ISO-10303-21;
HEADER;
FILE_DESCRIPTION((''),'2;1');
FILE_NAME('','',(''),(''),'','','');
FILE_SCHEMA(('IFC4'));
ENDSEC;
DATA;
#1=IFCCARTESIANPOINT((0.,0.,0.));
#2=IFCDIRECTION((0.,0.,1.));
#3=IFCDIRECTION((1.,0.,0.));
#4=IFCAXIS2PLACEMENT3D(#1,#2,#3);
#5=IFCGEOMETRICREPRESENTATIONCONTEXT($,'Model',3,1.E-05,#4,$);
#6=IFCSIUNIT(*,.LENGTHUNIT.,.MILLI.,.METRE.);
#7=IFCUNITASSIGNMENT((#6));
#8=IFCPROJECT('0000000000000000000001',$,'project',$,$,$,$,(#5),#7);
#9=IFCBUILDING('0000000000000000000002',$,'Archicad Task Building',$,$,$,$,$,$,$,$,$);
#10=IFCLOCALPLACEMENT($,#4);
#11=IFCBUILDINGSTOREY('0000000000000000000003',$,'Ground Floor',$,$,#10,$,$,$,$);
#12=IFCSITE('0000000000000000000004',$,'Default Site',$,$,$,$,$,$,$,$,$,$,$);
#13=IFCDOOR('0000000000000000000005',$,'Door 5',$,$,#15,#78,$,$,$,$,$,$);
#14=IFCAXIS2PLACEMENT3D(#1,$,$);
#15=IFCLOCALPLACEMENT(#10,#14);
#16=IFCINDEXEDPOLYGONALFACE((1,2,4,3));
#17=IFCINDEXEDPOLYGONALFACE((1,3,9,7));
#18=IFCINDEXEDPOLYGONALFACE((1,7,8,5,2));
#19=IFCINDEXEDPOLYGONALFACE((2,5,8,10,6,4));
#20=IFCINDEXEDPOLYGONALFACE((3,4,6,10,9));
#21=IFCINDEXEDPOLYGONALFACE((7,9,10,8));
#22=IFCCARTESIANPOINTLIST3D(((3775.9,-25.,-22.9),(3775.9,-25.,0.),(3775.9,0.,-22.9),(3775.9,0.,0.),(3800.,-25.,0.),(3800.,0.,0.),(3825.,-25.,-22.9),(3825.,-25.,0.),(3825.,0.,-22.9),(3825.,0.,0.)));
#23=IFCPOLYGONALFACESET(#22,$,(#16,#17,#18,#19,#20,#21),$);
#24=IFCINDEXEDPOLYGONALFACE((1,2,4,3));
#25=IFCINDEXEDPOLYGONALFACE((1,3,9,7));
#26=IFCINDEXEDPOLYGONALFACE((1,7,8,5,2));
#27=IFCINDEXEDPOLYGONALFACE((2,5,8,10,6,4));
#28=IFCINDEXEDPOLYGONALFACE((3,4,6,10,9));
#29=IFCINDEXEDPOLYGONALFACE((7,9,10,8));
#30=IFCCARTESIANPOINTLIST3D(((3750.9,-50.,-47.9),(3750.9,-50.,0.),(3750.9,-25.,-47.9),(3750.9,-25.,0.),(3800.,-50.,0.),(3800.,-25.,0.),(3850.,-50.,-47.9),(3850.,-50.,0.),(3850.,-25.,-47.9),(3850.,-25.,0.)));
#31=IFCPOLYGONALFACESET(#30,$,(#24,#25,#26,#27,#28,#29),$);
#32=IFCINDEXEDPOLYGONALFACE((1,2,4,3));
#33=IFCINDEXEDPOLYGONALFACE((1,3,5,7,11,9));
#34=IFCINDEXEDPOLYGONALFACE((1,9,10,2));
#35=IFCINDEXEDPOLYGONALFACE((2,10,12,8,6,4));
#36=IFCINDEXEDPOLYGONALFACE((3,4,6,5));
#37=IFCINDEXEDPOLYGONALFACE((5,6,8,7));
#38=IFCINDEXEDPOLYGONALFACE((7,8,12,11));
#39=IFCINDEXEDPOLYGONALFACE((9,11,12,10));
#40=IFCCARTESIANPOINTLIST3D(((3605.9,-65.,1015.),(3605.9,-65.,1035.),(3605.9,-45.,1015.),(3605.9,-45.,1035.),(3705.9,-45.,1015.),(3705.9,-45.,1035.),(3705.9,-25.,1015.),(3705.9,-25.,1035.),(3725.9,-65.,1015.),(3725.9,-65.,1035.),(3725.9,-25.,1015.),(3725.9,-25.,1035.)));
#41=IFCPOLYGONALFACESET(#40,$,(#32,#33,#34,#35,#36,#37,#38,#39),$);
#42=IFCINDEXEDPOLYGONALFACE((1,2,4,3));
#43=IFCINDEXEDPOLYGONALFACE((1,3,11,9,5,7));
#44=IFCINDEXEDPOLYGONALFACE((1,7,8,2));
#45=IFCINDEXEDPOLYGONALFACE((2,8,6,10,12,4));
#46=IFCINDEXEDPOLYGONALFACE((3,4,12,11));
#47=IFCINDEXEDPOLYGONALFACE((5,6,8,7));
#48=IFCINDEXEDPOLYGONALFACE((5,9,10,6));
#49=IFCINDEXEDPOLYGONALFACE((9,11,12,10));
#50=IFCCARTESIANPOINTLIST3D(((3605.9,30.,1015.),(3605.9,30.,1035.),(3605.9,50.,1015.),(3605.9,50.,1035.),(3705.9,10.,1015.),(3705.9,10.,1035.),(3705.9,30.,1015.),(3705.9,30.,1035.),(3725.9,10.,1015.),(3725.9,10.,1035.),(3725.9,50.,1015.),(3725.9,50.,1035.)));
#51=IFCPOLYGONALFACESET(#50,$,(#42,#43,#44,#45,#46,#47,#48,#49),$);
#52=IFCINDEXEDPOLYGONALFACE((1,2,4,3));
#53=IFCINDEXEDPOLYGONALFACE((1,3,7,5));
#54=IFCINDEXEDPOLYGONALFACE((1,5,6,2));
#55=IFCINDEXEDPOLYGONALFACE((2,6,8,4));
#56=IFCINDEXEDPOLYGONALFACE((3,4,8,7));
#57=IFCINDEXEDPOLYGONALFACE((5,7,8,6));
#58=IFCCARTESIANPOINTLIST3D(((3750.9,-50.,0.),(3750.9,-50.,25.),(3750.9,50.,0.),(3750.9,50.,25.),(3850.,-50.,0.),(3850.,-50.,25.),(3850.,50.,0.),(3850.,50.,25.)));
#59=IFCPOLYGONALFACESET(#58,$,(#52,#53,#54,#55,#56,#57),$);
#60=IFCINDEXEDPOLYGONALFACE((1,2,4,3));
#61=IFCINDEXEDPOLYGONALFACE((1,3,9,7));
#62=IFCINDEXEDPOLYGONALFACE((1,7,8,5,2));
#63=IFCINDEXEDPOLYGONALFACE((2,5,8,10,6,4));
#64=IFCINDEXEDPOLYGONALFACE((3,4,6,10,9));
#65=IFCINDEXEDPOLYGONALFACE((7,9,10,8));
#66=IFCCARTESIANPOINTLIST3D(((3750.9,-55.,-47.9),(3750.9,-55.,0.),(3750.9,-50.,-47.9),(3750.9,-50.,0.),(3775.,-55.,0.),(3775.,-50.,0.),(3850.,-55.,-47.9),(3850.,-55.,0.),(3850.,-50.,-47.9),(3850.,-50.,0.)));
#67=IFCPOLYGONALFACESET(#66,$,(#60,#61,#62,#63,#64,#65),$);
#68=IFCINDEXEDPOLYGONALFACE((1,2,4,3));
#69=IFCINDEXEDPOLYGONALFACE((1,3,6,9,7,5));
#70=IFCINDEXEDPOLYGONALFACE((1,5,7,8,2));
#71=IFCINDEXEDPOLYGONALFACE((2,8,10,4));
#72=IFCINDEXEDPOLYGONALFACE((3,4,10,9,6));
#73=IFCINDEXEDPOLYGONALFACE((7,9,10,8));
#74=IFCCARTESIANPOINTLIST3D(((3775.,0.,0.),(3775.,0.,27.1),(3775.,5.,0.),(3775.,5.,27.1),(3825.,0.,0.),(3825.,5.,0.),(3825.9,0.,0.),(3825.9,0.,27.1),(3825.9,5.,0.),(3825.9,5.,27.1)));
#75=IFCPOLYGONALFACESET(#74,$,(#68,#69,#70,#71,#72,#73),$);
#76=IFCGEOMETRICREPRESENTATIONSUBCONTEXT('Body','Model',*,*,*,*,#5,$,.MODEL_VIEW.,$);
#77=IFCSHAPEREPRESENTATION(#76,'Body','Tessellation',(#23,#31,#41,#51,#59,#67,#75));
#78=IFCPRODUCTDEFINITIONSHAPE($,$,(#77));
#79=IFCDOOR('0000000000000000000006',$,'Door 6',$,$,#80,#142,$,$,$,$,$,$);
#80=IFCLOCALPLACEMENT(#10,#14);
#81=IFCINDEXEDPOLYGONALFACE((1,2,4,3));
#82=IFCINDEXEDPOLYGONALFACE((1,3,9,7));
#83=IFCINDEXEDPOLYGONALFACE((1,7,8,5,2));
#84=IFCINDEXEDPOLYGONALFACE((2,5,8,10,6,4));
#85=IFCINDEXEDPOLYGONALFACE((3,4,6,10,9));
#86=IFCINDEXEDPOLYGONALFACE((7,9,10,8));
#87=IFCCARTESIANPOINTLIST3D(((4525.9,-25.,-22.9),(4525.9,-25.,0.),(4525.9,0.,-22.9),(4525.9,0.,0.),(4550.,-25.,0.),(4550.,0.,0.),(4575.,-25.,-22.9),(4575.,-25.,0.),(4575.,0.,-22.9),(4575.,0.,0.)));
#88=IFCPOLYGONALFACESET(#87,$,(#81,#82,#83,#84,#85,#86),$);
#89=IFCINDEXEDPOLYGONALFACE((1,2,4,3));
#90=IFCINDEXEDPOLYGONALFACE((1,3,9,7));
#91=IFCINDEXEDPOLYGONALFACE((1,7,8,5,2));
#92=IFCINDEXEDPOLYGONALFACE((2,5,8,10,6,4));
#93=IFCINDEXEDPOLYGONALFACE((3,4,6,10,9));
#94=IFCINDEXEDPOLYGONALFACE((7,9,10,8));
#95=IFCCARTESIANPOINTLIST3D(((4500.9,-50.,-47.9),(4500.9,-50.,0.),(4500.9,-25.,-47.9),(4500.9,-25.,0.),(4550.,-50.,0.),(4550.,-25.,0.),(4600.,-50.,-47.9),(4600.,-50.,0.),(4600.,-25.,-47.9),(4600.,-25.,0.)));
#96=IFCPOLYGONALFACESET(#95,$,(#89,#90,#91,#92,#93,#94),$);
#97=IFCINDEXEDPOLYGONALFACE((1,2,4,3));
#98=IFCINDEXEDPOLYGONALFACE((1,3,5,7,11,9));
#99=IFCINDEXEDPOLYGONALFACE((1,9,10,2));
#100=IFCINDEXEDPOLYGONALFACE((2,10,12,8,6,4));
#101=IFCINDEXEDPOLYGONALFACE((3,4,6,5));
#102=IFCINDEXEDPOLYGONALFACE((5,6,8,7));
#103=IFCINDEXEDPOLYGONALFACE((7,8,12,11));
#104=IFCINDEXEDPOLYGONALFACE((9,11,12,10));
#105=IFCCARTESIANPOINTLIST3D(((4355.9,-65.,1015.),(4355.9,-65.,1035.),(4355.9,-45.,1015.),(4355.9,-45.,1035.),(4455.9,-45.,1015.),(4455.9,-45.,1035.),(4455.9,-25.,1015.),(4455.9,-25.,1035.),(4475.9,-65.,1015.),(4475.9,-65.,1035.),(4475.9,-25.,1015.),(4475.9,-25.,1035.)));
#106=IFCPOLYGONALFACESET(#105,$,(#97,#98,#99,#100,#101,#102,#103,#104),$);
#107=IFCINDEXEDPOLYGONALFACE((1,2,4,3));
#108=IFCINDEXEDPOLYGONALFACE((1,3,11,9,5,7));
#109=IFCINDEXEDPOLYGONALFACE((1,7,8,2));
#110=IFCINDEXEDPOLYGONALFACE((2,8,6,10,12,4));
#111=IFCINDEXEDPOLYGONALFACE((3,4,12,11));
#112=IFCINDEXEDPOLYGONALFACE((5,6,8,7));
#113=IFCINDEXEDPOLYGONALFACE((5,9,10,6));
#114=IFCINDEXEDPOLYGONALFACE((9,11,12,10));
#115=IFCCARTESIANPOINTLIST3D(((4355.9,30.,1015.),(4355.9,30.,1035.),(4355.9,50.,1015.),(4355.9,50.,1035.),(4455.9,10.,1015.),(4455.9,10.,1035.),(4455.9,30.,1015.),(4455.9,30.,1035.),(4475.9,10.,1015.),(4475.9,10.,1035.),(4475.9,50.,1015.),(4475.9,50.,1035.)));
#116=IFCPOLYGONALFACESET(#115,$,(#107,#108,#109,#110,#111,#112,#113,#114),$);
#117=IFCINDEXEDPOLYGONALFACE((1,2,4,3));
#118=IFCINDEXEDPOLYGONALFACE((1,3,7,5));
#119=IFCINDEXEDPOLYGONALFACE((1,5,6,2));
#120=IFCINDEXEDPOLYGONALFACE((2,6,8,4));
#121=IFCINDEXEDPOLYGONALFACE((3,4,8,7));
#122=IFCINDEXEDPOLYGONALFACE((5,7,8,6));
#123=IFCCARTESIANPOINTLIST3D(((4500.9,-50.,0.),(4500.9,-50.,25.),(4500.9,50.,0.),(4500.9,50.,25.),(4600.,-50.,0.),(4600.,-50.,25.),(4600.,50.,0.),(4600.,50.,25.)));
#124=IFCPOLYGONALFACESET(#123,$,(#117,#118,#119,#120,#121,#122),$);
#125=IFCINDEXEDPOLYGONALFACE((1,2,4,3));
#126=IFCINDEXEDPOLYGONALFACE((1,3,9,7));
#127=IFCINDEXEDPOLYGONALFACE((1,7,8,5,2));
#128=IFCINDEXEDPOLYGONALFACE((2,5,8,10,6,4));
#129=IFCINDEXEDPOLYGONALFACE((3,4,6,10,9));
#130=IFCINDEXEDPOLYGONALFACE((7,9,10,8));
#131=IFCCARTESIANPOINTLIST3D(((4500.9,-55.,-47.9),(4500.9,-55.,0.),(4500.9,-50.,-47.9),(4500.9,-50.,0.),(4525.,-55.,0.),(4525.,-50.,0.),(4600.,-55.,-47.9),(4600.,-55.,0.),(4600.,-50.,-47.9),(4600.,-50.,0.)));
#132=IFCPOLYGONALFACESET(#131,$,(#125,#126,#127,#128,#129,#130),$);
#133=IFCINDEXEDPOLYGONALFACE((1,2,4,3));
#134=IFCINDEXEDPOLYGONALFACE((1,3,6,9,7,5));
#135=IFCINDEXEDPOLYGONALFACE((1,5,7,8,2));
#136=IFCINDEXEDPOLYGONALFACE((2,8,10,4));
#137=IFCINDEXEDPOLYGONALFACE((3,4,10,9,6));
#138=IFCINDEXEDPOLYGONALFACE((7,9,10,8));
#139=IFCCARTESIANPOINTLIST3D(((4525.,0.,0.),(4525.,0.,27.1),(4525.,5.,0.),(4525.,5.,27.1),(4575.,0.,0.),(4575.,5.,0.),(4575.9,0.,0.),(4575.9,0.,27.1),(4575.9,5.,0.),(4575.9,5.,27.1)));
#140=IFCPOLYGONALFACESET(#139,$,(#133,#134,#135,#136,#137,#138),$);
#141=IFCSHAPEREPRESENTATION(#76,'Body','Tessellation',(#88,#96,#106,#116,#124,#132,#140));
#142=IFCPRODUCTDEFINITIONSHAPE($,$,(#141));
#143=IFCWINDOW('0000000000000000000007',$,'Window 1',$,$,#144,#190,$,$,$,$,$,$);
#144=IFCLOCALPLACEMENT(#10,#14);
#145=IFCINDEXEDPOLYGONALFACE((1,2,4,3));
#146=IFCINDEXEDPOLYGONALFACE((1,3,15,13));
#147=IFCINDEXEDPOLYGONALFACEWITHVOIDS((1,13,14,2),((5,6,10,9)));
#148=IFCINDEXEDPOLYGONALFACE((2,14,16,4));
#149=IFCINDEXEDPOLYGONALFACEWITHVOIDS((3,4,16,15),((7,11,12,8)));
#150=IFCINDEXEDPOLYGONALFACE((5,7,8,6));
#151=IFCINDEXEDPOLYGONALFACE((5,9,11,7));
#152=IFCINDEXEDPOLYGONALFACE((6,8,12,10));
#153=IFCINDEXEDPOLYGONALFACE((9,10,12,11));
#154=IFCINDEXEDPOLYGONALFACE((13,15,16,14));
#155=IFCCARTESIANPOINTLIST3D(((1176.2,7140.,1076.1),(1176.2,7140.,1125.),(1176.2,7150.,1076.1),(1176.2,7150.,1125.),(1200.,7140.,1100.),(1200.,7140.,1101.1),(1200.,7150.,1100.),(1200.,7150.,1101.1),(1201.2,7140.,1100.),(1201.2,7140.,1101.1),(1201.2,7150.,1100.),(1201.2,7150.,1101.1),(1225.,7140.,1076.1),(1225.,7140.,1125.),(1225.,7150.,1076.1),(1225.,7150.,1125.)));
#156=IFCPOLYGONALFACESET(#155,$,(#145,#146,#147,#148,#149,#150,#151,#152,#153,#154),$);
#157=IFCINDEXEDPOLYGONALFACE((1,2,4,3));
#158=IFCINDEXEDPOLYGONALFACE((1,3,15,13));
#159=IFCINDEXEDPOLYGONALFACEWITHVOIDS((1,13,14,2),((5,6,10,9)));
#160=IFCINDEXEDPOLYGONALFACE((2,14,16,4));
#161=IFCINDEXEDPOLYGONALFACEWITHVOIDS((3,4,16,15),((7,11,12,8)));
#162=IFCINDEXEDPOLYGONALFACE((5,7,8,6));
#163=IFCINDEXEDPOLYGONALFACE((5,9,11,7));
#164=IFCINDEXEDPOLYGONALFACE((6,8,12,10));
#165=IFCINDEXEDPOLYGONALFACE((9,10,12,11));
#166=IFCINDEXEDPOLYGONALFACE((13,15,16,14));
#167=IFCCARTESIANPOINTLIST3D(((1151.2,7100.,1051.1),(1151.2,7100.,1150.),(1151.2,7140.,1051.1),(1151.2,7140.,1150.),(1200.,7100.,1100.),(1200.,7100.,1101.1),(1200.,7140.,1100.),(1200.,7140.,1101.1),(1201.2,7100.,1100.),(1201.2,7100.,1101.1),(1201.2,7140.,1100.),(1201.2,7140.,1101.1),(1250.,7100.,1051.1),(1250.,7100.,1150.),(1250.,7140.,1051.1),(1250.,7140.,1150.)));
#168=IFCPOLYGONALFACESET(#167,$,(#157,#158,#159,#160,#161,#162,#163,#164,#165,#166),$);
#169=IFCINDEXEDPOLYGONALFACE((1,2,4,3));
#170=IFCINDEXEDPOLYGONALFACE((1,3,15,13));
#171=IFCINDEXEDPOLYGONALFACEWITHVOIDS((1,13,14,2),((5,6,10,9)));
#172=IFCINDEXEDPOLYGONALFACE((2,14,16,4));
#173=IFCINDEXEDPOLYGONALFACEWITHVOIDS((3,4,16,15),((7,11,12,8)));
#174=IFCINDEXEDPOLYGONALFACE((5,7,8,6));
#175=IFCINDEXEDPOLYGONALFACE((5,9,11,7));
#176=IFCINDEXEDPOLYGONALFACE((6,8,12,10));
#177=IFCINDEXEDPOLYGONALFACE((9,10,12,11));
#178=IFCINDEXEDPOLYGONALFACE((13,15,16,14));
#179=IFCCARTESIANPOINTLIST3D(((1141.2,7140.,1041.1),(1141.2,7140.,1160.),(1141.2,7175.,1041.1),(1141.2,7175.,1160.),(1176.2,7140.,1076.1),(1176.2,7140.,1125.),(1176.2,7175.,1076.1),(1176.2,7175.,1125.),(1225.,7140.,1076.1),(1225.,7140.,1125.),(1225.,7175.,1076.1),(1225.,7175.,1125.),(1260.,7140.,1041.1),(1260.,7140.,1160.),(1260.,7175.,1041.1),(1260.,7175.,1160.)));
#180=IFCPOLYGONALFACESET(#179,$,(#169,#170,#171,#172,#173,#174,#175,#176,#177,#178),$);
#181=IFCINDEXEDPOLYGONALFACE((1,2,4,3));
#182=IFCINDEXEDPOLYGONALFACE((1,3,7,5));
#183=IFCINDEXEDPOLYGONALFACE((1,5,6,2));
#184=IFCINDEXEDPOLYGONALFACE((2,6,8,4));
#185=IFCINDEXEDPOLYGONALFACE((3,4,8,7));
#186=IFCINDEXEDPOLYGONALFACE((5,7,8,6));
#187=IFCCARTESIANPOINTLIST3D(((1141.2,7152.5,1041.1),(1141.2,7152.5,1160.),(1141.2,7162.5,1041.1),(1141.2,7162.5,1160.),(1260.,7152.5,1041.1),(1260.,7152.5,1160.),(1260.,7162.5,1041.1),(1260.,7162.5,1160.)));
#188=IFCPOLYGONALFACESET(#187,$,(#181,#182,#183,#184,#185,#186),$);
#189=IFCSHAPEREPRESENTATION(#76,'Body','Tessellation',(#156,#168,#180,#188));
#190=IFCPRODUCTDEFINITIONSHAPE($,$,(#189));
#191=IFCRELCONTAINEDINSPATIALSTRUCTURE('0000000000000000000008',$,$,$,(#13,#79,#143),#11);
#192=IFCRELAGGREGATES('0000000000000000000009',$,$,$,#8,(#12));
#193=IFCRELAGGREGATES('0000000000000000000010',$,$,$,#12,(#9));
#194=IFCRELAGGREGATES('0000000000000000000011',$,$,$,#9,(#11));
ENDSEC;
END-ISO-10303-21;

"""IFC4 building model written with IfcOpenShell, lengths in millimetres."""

from ifc_helpers import new_model, si_unit, frame, origin_with_axes, place, context, subcontext, project, spatial, line, indexed_curve, outline, extrude, element, save


model = new_model("IFC4")

# Units and contexts
model_context = context("Model", 3, precision=1e-05, world=origin_with_axes())
body_context = subcontext(model_context, "Body", "Model", "MODEL_VIEW")
ifc_project = project(units=[si_unit("LENGTHUNIT", "METRE", prefix="MILLI")], contexts=[model_context])

# Site, building, storey
site = spatial("IfcSite", under=ifc_project, Name="Default Site")
building = spatial("IfcBuilding", under=site, Name="Archicad Task Building")
storey_placement = place(None, origin_with_axes())
storey = spatial("IfcBuildingStorey", under=building, at=storey_placement, Name="Ground Floor")

# Doors
door_1_placement = place(storey_placement, frame((3800.0, -50.0, 0.0), z_axis=(0.0, 0.0, 1.0), x_axis=(1.0, 0.0, 0.0)))
element("IfcDoor", 1, at=door_1_placement, inside=storey, Name="Door 5", context=body_context, shape_type="SweptSolid", body=[
    extrude(outline(indexed_curve([(0.0, 0.0), (0.0, 2.1), (0.9, 2.1), (0.9, 0.0), (-24.1, 0.0), (-24.1, -22.9), (25.0, -22.9), (25.0, 0.0)], segments=[line(1, 2, 3, 4, 5, 6, 7, 8, 1)])), frame((0.0, 25.0, 0.0), z_axis=(0.0, -1.0, 0.0), x_axis=(1.0, 0.0, 0.0)), (0.0, 0.0, -1.0), 25.0),
    extrude(outline(indexed_curve([(0.0, 0.0), (0.0, 2.1), (0.9, 2.1), (0.9, 0.0), (-49.1, 0.0), (-49.1, -47.9), (50.0, -47.9), (50.0, 0.0)], segments=[line(1, 2, 3, 4, 5, 6, 7, 8, 1)])), frame((0.0, 0.0, 0.0), z_axis=(0.0, -1.0, 0.0), x_axis=(1.0, 0.0, 0.0)), (0.0, 0.0, -1.0), 25.0),
    extrude(outline(indexed_curve([(0.0, 0.0), (-49.1, 0.0), (-49.1, 35.0), (0.0, 35.0)], segments=[line(1, 2, 3, 4, 1)])), frame((25.0, 25.0, 25.0), z_axis=(0.0, 0.0, 1.0), x_axis=(1.0, 0.0, 0.0)), (0.0, 0.0, 1.0), -47.9),
    extrude(outline(indexed_curve([(0.0, 0.0), (0.0, -40.0), (-120.0, -40.0), (-120.0, -20.0), (-20.0, -20.0), (-20.0, 0.0)], segments=[line(1, 2, 3, 4, 5, 6, 1)])), frame((-74.1, 25.0, 1015.0), z_axis=(0.0, 0.0, 1.0), x_axis=(1.0, 0.0, 0.0)), (0.0, 0.0, 1.0), 20.0),
    extrude(outline(indexed_curve([(0.0, 0.0), (0.0, 40.0), (-120.0, 40.0), (-120.0, 20.0), (-20.0, 20.0), (-20.0, 0.0)], segments=[line(1, 2, 3, 4, 5, 6, 1)])), frame((-74.1, 60.0, 1015.0), z_axis=(0.0, 0.0, 1.0), x_axis=(1.0, 0.0, 0.0)), (0.0, 0.0, 1.0), 20.0),
    extrude(outline(indexed_curve([(0.0, 0.0), (-99.1, 0.0), (-99.1, 100.0), (0.0, 100.0)], segments=[line(1, 2, 3, 4, 1)])), frame((50.0, 0.0, 0.0), z_axis=(0.0, 0.0, 1.0), x_axis=(1.0, 0.0, 0.0)), (0.0, 0.0, 1.0), 25.0),
    extrude(outline(indexed_curve([(0.0, 0.0), (0.0, 27.1), (50.9, 27.1), (50.9, 0.0), (-24.1, 0.0), (-24.1, -47.9), (75.0, -47.9), (75.0, 0.0)], segments=[line(1, 2, 3, 4, 5, 6, 7, 8, 1)])), frame((-25.0, -5.0, 0.0), z_axis=(0.0, -1.0, 0.0), x_axis=(1.0, 0.0, 0.0)), (0.0, 0.0, -1.0), 5.0),
    extrude(outline(indexed_curve([(0.0, 0.0), (0.0, 27.1), (50.9, 27.1), (50.9, 0.0), (0.9, 0.0), (0.9, -22.9), (50.0, -22.9), (50.0, 0.0)], segments=[line(1, 2, 3, 4, 5, 6, 7, 8, 1)])), frame((-25.0, 50.0, 0.0), z_axis=(0.0, -1.0, 0.0), x_axis=(1.0, 0.0, 0.0)), (0.0, 0.0, -1.0), 5.0),
])
door_2_placement = place(storey_placement, frame((4550.0, -50.0, 0.0), z_axis=(0.0, 0.0, 1.0), x_axis=(1.0, 0.0, 0.0)))
element("IfcDoor", 2, at=door_2_placement, inside=storey, Name="Door 6", context=body_context, shape_type="SweptSolid", body=[
    extrude(outline(indexed_curve([(0.0, 0.0), (0.0, 2.1), (0.9, 2.1), (0.9, 0.0), (-24.1, 0.0), (-24.1, -22.9), (25.0, -22.9), (25.0, 0.0)], segments=[line(1, 2, 3, 4, 5, 6, 7, 8, 1)])), frame((0.0, 25.0, 0.0), z_axis=(0.0, -1.0, 0.0), x_axis=(1.0, 0.0, 0.0)), (0.0, 0.0, -1.0), 25.0),
    extrude(outline(indexed_curve([(0.0, 0.0), (0.0, 2.1), (0.9, 2.1), (0.9, 0.0), (-49.1, 0.0), (-49.1, -47.9), (50.0, -47.9), (50.0, 0.0)], segments=[line(1, 2, 3, 4, 5, 6, 7, 8, 1)])), frame((0.0, 0.0, 0.0), z_axis=(0.0, -1.0, 0.0), x_axis=(1.0, 0.0, 0.0)), (0.0, 0.0, -1.0), 25.0),
    extrude(outline(indexed_curve([(0.0, 0.0), (-49.1, 0.0), (-49.1, 35.0), (0.0, 35.0)], segments=[line(1, 2, 3, 4, 1)])), frame((25.0, 25.0, 25.0), z_axis=(0.0, 0.0, 1.0), x_axis=(1.0, 0.0, 0.0)), (0.0, 0.0, 1.0), -47.9),
    extrude(outline(indexed_curve([(0.0, 0.0), (0.0, -40.0), (-120.0, -40.0), (-120.0, -20.0), (-20.0, -20.0), (-20.0, 0.0)], segments=[line(1, 2, 3, 4, 5, 6, 1)])), frame((-74.1, 25.0, 1015.0), z_axis=(0.0, 0.0, 1.0), x_axis=(1.0, 0.0, 0.0)), (0.0, 0.0, 1.0), 20.0),
    extrude(outline(indexed_curve([(0.0, 0.0), (0.0, 40.0), (-120.0, 40.0), (-120.0, 20.0), (-20.0, 20.0), (-20.0, 0.0)], segments=[line(1, 2, 3, 4, 5, 6, 1)])), frame((-74.1, 60.0, 1015.0), z_axis=(0.0, 0.0, 1.0), x_axis=(1.0, 0.0, 0.0)), (0.0, 0.0, 1.0), 20.0),
    extrude(outline(indexed_curve([(0.0, 0.0), (-99.1, 0.0), (-99.1, 100.0), (0.0, 100.0)], segments=[line(1, 2, 3, 4, 1)])), frame((50.0, 0.0, 0.0), z_axis=(0.0, 0.0, 1.0), x_axis=(1.0, 0.0, 0.0)), (0.0, 0.0, 1.0), 25.0),
    extrude(outline(indexed_curve([(0.0, 0.0), (0.0, 27.1), (50.9, 27.1), (50.9, 0.0), (-24.1, 0.0), (-24.1, -47.9), (75.0, -47.9), (75.0, 0.0)], segments=[line(1, 2, 3, 4, 5, 6, 7, 8, 1)])), frame((-25.0, -5.0, 0.0), z_axis=(0.0, -1.0, 0.0), x_axis=(1.0, 0.0, 0.0)), (0.0, 0.0, -1.0), 5.0),
    extrude(outline(indexed_curve([(0.0, 0.0), (0.0, 27.1), (50.9, 27.1), (50.9, 0.0), (0.9, 0.0), (0.9, -22.9), (50.0, -22.9), (50.0, 0.0)], segments=[line(1, 2, 3, 4, 5, 6, 7, 8, 1)])), frame((-25.0, 50.0, 0.0), z_axis=(0.0, -1.0, 0.0), x_axis=(1.0, 0.0, 0.0)), (0.0, 0.0, -1.0), 5.0),
])

# Window
for number, where, z_axis, x_axis, name in (
    (3, (1200.0, 7050.0, 1100.0), (0.0, 0.0, 1.0), (1.0, 0.0, 0.0), "Window 1"),
):
    element("IfcWindow", number, at=place(storey_placement, frame(where, z_axis=z_axis, x_axis=x_axis)), inside=storey, Name=name, context=body_context, shape_type="SweptSolid", body=[
        extrude(outline(indexed_curve([(0.0, 0.0), (1.2, 0.0), (1.2, 1.1), (0.0, 1.1)], segments=[line(1, 2, 3, 4, 1)]), holes=[indexed_curve([(25.0, 25.0), (-23.8, 25.0), (-23.8, -23.9), (25.0, -23.9)], segments=[line(1, 2, 3, 4, 1)])]), frame((0.0, 90.0, 0.0), z_axis=(0.0, -1.0, 0.0), x_axis=(1.0, 0.0, 0.0)), (0.0, 0.0, -1.0), 10.0),
        extrude(outline(indexed_curve([(0.0, 0.0), (1.2, 0.0), (1.2, 1.1), (0.0, 1.1)], segments=[line(1, 2, 3, 4, 1)]), holes=[indexed_curve([(50.0, 50.0), (-48.8, 50.0), (-48.8, -48.9), (50.0, -48.9)], segments=[line(1, 2, 3, 4, 1)])]), frame((0.0, 50.0, 0.0), z_axis=(0.0, -1.0, 0.0), x_axis=(1.0, 0.0, 0.0)), (0.0, 0.0, -1.0), 40.0),
        extrude(outline(indexed_curve([(0.0, 0.0), (-48.8, 0.0), (-48.8, -48.9), (0.0, -48.9)], segments=[line(1, 2, 3, 4, 1)]), holes=[indexed_curve([(35.0, 35.0), (-83.8, 35.0), (-83.8, -83.9), (35.0, -83.9)], segments=[line(1, 2, 3, 4, 1)])]), frame((25.0, 90.0, 25.0), z_axis=(0.0, -1.0, 0.0), x_axis=(1.0, 0.0, 0.0)), (0.0, 0.0, -1.0), 35.0),
        extrude(outline(indexed_curve([(35.0, 35.0), (-83.8, 35.0), (-83.8, -83.9), (35.0, -83.9)], segments=[line(1, 2, 3, 4, 1)])), frame((25.0, 102.5, 25.0), z_axis=(0.0, -1.0, 0.0), x_axis=(1.0, 0.0, 0.0)), (0.0, 0.0, -1.0), 10.0),
    ])

save(model, "model.ifc")
